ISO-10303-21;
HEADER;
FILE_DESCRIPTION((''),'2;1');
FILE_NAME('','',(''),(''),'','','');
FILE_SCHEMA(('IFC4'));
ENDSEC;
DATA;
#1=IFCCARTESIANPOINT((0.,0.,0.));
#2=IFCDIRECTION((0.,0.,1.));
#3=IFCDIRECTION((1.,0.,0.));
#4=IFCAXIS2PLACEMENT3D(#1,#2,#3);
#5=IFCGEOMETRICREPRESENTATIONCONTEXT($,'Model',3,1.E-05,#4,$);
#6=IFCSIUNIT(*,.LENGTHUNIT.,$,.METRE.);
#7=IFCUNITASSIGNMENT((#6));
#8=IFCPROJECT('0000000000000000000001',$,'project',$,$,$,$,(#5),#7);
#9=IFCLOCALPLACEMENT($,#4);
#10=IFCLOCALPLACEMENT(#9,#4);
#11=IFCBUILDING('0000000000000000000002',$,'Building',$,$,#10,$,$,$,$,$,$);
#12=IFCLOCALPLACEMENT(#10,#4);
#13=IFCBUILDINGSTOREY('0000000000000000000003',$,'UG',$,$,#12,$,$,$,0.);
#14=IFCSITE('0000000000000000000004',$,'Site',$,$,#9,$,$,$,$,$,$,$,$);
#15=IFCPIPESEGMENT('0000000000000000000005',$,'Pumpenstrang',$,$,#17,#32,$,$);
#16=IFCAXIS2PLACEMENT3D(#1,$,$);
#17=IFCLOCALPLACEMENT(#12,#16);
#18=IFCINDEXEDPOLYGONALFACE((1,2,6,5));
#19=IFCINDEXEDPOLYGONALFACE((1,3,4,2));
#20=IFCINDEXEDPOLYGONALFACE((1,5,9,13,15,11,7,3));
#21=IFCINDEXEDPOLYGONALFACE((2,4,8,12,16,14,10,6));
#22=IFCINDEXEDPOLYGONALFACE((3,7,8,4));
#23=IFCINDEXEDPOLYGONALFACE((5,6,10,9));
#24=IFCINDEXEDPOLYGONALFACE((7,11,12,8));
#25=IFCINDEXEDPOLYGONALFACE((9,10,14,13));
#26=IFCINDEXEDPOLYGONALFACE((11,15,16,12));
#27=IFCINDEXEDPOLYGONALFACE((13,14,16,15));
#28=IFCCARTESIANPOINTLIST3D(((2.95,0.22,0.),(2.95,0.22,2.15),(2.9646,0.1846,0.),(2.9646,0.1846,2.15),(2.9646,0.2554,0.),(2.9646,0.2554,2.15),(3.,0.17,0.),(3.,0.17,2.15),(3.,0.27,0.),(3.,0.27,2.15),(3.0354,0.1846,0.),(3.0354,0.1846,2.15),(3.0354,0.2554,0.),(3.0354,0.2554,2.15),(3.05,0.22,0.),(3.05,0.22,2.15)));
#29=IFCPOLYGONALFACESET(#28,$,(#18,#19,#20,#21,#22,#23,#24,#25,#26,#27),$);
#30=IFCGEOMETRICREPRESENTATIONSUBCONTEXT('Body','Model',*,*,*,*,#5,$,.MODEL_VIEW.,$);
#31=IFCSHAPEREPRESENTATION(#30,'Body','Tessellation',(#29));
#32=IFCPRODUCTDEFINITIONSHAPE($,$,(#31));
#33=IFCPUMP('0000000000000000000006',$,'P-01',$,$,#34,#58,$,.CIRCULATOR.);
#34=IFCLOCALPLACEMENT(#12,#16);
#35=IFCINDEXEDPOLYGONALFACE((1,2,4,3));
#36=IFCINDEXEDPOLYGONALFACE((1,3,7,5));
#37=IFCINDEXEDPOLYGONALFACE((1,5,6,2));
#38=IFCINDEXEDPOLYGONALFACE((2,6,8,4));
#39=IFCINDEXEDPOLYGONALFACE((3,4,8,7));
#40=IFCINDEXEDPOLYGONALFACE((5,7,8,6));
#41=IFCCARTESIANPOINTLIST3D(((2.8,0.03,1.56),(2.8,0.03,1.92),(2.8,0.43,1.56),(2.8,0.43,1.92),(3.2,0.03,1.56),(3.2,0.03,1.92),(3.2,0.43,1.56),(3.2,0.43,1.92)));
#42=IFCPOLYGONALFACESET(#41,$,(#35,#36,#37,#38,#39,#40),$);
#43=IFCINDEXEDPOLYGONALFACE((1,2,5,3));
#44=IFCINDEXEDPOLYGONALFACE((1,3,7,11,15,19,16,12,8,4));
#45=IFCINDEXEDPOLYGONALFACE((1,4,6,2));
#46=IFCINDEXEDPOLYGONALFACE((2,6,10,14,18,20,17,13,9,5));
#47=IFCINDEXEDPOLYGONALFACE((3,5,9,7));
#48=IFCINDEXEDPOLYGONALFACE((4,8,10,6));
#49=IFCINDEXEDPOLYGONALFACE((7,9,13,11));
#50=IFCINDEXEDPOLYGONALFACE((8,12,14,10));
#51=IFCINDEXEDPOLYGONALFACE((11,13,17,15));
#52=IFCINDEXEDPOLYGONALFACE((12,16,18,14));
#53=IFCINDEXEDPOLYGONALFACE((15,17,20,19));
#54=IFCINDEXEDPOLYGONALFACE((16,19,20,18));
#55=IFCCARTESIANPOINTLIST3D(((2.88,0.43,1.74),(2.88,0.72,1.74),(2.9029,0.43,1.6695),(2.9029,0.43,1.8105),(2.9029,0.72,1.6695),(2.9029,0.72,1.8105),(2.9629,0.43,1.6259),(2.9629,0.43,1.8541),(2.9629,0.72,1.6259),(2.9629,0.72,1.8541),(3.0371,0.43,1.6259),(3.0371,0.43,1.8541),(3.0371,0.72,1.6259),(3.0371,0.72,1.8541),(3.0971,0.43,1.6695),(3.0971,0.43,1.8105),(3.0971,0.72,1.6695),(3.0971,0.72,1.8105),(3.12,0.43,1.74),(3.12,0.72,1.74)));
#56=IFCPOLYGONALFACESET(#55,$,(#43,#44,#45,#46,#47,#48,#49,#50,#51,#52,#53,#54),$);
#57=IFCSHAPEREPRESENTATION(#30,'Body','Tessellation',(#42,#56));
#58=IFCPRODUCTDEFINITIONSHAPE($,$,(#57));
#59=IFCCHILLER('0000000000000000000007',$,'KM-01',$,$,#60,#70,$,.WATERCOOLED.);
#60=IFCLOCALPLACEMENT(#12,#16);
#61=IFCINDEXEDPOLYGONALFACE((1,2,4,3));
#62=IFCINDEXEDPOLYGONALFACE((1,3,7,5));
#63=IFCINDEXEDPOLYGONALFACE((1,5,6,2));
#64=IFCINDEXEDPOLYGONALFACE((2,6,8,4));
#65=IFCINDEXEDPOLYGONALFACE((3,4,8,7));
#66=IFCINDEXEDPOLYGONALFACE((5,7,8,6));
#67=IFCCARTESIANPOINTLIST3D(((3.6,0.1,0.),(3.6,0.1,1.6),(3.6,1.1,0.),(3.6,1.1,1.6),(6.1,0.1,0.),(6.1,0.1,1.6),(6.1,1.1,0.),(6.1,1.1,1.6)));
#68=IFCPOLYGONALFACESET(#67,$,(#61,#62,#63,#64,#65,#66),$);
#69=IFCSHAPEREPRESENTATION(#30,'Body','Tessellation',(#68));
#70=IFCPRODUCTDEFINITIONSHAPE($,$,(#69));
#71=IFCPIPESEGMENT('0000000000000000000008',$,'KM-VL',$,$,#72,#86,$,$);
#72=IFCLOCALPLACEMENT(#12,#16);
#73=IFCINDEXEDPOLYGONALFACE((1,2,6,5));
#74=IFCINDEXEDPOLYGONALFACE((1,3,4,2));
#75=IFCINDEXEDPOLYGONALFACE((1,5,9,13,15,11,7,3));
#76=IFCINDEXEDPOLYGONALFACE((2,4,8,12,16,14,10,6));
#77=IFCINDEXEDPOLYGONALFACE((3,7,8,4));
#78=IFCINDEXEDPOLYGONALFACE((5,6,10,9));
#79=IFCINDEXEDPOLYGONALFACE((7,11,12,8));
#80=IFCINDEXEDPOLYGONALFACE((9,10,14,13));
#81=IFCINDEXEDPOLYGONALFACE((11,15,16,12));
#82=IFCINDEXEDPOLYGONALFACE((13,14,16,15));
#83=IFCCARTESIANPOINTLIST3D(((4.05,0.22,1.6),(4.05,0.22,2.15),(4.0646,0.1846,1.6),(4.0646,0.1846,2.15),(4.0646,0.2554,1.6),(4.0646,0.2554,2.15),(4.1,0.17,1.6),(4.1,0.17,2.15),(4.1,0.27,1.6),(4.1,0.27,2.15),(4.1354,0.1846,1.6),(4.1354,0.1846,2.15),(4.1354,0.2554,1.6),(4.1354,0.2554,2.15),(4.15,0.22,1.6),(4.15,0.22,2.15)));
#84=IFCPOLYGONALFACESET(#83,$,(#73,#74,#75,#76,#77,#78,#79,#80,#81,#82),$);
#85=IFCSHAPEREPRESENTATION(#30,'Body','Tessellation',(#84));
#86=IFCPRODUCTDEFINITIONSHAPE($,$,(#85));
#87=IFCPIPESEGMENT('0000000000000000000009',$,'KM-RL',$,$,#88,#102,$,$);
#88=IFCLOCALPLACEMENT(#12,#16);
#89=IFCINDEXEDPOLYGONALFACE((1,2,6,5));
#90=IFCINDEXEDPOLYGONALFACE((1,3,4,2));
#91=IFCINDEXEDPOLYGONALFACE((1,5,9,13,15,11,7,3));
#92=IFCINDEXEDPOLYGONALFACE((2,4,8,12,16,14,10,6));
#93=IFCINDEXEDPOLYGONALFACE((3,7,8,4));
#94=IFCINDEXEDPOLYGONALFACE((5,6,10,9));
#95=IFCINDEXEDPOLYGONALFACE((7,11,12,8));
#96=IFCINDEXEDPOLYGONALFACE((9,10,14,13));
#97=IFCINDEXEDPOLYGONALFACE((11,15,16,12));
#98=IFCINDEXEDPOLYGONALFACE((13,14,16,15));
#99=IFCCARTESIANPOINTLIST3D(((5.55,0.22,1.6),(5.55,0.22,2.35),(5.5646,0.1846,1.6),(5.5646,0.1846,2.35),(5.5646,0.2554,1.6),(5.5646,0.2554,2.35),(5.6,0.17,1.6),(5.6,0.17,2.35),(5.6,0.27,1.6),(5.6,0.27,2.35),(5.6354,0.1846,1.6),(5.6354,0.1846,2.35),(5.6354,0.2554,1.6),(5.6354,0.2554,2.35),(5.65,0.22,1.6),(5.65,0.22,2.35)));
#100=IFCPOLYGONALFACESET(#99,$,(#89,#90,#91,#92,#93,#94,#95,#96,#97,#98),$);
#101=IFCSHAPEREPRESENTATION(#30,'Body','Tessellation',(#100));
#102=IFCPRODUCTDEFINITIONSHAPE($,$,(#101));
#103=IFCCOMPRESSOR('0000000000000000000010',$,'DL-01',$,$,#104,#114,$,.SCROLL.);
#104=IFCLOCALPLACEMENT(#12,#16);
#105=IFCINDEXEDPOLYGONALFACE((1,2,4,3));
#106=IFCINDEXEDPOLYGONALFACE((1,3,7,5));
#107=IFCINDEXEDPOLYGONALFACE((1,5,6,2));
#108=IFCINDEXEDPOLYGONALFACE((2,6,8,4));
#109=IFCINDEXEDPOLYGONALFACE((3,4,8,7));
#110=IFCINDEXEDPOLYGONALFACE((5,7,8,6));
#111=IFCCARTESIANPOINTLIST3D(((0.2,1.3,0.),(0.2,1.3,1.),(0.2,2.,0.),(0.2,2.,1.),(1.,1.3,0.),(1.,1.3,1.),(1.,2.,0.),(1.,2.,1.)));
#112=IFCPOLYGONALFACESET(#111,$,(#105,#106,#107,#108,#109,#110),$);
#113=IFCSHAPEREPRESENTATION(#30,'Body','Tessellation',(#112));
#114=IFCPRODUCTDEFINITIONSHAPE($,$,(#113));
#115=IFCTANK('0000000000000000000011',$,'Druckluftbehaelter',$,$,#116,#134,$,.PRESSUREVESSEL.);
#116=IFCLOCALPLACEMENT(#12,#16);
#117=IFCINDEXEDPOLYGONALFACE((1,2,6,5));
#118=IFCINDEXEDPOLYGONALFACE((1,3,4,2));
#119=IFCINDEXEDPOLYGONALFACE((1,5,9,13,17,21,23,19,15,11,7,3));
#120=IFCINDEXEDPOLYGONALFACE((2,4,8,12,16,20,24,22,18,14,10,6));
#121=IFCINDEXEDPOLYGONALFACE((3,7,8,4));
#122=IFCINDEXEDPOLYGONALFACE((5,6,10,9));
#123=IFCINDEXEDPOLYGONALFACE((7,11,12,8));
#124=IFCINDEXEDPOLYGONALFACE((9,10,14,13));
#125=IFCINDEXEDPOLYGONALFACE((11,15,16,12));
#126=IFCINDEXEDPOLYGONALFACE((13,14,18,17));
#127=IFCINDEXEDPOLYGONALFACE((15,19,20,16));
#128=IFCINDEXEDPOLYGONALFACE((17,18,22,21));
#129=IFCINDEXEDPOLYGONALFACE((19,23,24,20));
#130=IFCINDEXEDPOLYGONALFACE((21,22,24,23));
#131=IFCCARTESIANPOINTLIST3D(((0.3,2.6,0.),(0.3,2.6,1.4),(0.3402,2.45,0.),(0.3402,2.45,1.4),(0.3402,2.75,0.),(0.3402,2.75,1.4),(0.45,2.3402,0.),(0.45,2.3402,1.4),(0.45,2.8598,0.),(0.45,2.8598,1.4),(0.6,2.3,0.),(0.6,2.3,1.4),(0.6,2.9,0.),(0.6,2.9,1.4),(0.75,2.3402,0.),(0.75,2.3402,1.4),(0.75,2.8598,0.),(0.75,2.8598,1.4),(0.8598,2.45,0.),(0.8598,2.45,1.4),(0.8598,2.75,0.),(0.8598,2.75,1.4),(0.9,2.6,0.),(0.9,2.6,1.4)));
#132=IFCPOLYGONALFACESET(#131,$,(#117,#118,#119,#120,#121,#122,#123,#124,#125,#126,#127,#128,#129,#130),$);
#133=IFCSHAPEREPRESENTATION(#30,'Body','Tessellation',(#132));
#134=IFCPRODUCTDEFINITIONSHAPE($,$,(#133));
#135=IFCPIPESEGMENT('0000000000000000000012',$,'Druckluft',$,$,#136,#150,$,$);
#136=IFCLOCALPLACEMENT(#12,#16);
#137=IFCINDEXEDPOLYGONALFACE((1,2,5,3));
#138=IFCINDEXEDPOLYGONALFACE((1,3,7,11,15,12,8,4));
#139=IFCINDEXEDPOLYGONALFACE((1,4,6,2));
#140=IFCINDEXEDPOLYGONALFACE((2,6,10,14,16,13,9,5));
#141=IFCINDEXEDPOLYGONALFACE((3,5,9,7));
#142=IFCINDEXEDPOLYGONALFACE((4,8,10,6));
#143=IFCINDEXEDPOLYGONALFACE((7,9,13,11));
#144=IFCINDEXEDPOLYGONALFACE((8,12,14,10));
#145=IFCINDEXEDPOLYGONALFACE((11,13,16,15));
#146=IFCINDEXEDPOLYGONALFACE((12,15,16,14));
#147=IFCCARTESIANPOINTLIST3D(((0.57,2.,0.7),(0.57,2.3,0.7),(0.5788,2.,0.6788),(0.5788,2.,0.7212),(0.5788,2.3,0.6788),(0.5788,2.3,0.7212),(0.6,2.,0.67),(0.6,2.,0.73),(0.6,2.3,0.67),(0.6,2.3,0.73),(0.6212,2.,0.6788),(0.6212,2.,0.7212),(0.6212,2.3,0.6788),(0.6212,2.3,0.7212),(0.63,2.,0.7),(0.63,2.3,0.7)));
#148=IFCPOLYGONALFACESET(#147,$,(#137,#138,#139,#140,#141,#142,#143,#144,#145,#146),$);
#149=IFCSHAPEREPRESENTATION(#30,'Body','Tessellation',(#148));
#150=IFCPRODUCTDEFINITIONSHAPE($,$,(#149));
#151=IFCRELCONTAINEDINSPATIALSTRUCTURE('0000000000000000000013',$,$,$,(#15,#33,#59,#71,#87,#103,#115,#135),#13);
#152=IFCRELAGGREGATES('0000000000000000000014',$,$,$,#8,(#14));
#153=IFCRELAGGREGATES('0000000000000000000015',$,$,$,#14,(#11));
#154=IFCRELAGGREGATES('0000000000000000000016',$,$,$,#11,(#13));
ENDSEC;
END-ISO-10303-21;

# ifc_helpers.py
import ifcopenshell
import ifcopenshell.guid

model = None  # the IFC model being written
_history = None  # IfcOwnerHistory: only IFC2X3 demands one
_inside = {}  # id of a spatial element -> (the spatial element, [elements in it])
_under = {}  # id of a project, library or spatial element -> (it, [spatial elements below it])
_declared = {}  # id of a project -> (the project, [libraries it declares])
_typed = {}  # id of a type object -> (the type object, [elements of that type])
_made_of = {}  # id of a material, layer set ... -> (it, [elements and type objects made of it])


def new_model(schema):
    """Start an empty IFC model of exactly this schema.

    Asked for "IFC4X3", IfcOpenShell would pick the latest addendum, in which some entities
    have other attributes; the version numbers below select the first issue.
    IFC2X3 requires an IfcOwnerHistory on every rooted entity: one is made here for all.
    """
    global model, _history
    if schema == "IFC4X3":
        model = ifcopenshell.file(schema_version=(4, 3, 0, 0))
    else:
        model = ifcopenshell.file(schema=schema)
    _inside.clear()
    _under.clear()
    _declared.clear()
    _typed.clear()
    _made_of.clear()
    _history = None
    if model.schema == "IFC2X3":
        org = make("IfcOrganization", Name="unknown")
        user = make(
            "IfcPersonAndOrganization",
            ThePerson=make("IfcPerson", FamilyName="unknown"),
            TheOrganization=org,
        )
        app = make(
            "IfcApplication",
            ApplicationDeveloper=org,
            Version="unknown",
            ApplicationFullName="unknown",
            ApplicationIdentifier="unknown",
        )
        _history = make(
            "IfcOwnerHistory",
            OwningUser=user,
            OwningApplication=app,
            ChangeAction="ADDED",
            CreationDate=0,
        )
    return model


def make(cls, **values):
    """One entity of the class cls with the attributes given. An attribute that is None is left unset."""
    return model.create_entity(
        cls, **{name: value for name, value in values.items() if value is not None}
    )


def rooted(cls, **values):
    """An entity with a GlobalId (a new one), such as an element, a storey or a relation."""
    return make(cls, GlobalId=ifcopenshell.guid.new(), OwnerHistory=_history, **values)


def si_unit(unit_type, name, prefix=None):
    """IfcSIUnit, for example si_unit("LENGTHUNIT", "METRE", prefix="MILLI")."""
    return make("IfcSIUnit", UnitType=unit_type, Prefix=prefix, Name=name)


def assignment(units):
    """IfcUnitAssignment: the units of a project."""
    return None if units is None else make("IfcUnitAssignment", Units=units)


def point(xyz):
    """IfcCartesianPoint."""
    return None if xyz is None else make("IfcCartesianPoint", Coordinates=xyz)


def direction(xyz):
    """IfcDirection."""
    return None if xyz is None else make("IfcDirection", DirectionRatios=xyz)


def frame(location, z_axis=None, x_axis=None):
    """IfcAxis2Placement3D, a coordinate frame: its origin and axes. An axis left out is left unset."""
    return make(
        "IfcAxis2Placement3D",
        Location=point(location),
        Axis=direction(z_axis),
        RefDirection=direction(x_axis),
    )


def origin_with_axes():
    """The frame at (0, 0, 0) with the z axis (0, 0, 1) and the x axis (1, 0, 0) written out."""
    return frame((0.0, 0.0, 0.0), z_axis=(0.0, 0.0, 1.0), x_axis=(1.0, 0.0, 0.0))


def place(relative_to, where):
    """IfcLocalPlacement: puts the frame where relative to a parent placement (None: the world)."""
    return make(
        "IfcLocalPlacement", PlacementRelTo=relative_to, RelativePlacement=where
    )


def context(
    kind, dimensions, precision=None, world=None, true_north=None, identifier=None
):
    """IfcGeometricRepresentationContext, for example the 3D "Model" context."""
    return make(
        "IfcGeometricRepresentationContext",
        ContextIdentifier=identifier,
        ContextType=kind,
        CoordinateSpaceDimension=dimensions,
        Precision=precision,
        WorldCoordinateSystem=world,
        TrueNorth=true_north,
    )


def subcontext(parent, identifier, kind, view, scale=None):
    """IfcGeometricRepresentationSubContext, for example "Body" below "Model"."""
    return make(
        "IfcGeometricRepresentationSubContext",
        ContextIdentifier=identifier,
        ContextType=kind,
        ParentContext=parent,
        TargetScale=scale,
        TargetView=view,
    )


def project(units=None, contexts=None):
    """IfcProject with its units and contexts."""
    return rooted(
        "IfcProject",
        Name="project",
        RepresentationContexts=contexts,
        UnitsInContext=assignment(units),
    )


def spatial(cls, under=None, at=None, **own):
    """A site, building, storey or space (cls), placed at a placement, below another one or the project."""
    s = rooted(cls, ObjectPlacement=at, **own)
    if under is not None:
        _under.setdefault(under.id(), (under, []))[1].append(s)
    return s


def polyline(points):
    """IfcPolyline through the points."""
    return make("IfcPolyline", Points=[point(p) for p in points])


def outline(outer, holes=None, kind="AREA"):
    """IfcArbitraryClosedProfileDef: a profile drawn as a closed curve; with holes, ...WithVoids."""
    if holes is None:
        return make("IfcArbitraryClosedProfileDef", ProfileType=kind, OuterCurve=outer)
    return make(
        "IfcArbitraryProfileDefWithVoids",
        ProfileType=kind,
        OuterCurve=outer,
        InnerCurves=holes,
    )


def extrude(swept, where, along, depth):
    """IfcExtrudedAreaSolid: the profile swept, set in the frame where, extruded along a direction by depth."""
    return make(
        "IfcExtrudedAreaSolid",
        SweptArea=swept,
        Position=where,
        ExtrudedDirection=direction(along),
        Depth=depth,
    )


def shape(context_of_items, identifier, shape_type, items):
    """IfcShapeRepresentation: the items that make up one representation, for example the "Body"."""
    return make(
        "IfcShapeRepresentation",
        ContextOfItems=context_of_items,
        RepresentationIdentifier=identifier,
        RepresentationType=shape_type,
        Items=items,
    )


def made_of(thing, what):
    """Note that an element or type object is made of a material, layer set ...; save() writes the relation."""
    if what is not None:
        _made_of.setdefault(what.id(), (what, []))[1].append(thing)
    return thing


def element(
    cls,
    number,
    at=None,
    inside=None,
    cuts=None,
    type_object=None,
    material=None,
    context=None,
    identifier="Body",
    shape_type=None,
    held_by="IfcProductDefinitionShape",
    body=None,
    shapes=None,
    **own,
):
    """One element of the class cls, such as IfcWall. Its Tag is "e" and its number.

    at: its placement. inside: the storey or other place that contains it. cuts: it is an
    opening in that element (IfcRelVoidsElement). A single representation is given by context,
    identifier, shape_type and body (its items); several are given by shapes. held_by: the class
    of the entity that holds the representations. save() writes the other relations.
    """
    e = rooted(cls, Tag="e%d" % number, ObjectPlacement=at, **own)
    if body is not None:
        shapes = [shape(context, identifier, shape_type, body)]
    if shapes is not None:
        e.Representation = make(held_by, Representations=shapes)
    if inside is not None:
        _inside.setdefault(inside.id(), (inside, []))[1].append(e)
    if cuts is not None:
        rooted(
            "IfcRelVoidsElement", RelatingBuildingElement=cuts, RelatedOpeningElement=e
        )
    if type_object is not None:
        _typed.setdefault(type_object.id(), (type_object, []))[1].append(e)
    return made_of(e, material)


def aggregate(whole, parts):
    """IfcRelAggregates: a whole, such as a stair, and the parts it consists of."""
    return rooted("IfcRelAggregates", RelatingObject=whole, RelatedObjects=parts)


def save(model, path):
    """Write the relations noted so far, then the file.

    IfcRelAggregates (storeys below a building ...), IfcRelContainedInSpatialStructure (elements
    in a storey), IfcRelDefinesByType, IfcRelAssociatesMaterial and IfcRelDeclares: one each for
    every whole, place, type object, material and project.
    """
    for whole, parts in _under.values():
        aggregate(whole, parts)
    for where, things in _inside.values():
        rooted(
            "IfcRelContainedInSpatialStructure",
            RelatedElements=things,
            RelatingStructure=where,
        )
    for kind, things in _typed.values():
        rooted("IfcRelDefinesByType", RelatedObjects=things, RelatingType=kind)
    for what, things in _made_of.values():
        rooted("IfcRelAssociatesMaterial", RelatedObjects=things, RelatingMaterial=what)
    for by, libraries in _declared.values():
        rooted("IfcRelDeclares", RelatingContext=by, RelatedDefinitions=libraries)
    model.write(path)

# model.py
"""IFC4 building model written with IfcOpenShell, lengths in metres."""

from ifc_helpers import new_model, si_unit, frame, origin_with_axes, place, context, subcontext, project, spatial, polyline, outline, extrude, element, save


model = new_model("IFC4")

# Units and contexts
model_context = context("Model", 3, precision=1e-05, world=origin_with_axes())
body_context = subcontext(model_context, "Body", "Model", "MODEL_VIEW")
ifc_project = project(units=[si_unit("LENGTHUNIT", "METRE")], contexts=[model_context])

# Site, building, storey
site_placement = place(None, origin_with_axes())
site = spatial("IfcSite", under=ifc_project, at=site_placement, Name="Site")
building_placement = place(site_placement, origin_with_axes())
building = spatial("IfcBuilding", under=site, at=building_placement, Name="Building")
storey_placement = place(building_placement, origin_with_axes())
storey = spatial("IfcBuildingStorey", under=building, at=storey_placement, Name="UG", Elevation=0.0)

# Pipe segment
pipe_segment_1_placement = place(storey_placement, origin_with_axes())
element("IfcPipeSegment", 1, at=pipe_segment_1_placement, inside=storey, Name="Pumpenstrang", context=body_context, shape_type="SweptSolid", body=[
    extrude(outline(polyline([(0.05, 0.0, 0.0), (0.0354, 0.0354, 0.0), (0.0, 0.05, 0.0), (-0.0354, 0.0354, 0.0), (-0.05, 0.0, 0.0), (-0.0354, -0.0354, 0.0), (0.0, -0.05, 0.0), (0.0354, -0.0354, 0.0), (0.05, 0.0, 0.0)])), frame((3.0, 0.22, 0.0), z_axis=(0.0, 0.0, 1.0), x_axis=(1.0, 0.0, 0.0)), (0.0, 0.0, 1.0), 2.15),
])

# Pump
pump_placement = place(storey_placement, origin_with_axes())
element("IfcPump", 2, at=pump_placement, inside=storey, Name="P-01", PredefinedType="CIRCULATOR", context=body_context, shape_type="SweptSolid", body=[
    extrude(outline(polyline([(2.8, 0.03, 0.0), (3.2, 0.03, 0.0), (3.2, 0.43, 0.0), (2.8, 0.43, 0.0), (2.8, 0.03, 0.0)])), frame((0.0, 0.0, 1.56), z_axis=(0.0, 0.0, 1.0), x_axis=(1.0, 0.0, 0.0)), (0.0, 0.0, 1.0), 0.36),
    extrude(outline(polyline([(0.12, 0.0, 0.0), (0.0971, 0.0705, 0.0), (0.0371, 0.1141, 0.0), (-0.0371, 0.1141, 0.0), (-0.0971, 0.0705, 0.0), (-0.12, 0.0, 0.0), (-0.0971, -0.0705, 0.0), (-0.0371, -0.1141, 0.0), (0.0371, -0.1141, 0.0), (0.0971, -0.0705, 0.0), (0.12, 0.0, 0.0)])), frame((3.0, 0.43, 1.74), z_axis=(0.0, 1.0, 0.0), x_axis=(-1.0, 0.0, 0.0)), (0.0, 0.0, 1.0), 0.29),
])

# Chiller
chiller_placement = place(storey_placement, origin_with_axes())
element("IfcChiller", 3, at=chiller_placement, inside=storey, Name="KM-01", PredefinedType="WATERCOOLED", context=body_context, shape_type="SweptSolid", body=[
    extrude(outline(polyline([(3.6, 0.1, 0.0), (6.1, 0.1, 0.0), (6.1, 1.1, 0.0), (3.6, 1.1, 0.0), (3.6, 0.1, 0.0)])), origin_with_axes(), (0.0, 0.0, 1.0), 1.6),
])

# Pipe segments
pipe_segment_2_placement = place(storey_placement, origin_with_axes())
element("IfcPipeSegment", 4, at=pipe_segment_2_placement, inside=storey, Name="KM-VL", context=body_context, shape_type="SweptSolid", body=[
    extrude(outline(polyline([(0.05, 0.0, 0.0), (0.0354, 0.0354, 0.0), (0.0, 0.05, 0.0), (-0.0354, 0.0354, 0.0), (-0.05, 0.0, 0.0), (-0.0354, -0.0354, 0.0), (0.0, -0.05, 0.0), (0.0354, -0.0354, 0.0), (0.05, 0.0, 0.0)])), frame((4.1, 0.22, 1.6), z_axis=(0.0, 0.0, 1.0), x_axis=(1.0, 0.0, 0.0)), (0.0, 0.0, 1.0), 0.55),
])
pipe_segment_3_placement = place(storey_placement, origin_with_axes())
element("IfcPipeSegment", 5, at=pipe_segment_3_placement, inside=storey, Name="KM-RL", context=body_context, shape_type="SweptSolid", body=[
    extrude(outline(polyline([(0.05, 0.0, 0.0), (0.0354, 0.0354, 0.0), (0.0, 0.05, 0.0), (-0.0354, 0.0354, 0.0), (-0.05, 0.0, 0.0), (-0.0354, -0.0354, 0.0), (0.0, -0.05, 0.0), (0.0354, -0.0354, 0.0), (0.05, 0.0, 0.0)])), frame((5.6, 0.22, 1.6), z_axis=(0.0, 0.0, 1.0), x_axis=(1.0, 0.0, 0.0)), (0.0, 0.0, 1.0), 0.75),
])

# Compressor
compressor_placement = place(storey_placement, origin_with_axes())
element("IfcCompressor", 6, at=compressor_placement, inside=storey, Name="DL-01", PredefinedType="SCROLL", context=body_context, shape_type="SweptSolid", body=[
    extrude(outline(polyline([(0.2, 1.3, 0.0), (1.0, 1.3, 0.0), (1.0, 2.0, 0.0), (0.2, 2.0, 0.0), (0.2, 1.3, 0.0)])), origin_with_axes(), (0.0, 0.0, 1.0), 1.0),
])

# Tank
tank_1_placement = place(storey_placement, origin_with_axes())
element("IfcTank", 7, at=tank_1_placement, inside=storey, Name="Druckluftbehaelter", PredefinedType="PRESSUREVESSEL", context=body_context, shape_type="SweptSolid", body=[
    extrude(outline(polyline([(0.3, 0.0, 0.0), (0.2598, 0.15, 0.0), (0.15, 0.2598, 0.0), (0.0, 0.3, 0.0), (-0.15, 0.2598, 0.0), (-0.2598, 0.15, 0.0), (-0.3, 0.0, 0.0), (-0.2598, -0.15, 0.0), (-0.15, -0.2598, 0.0), (0.0, -0.3, 0.0), (0.15, -0.2598, 0.0), (0.2598, -0.15, 0.0), (0.3, 0.0, 0.0)])), frame((0.6, 2.6, 0.0), z_axis=(0.0, 0.0, 1.0), x_axis=(1.0, 0.0, 0.0)), (0.0, 0.0, 1.0), 1.4),
])

# Pipe segment
pipe_segment_4_placement = place(storey_placement, origin_with_axes())
element("IfcPipeSegment", 8, at=pipe_segment_4_placement, inside=storey, Name="Druckluft", context=body_context, shape_type="SweptSolid", body=[
    extrude(outline(polyline([(0.03, 0.0, 0.0), (0.0212, 0.0212, 0.0), (0.0, 0.03, 0.0), (-0.0212, 0.0212, 0.0), (-0.03, 0.0, 0.0), (-0.0212, -0.0212, 0.0), (0.0, -0.03, 0.0), (0.0212, -0.0212, 0.0), (0.03, 0.0, 0.0)])), frame((0.6, 2.0, 0.7), z_axis=(0.0, 1.0, 0.0), x_axis=(-1.0, 0.0, 0.0)), (0.0, 0.0, 1.0), 0.3),
])

save(model, "model.ifc")
